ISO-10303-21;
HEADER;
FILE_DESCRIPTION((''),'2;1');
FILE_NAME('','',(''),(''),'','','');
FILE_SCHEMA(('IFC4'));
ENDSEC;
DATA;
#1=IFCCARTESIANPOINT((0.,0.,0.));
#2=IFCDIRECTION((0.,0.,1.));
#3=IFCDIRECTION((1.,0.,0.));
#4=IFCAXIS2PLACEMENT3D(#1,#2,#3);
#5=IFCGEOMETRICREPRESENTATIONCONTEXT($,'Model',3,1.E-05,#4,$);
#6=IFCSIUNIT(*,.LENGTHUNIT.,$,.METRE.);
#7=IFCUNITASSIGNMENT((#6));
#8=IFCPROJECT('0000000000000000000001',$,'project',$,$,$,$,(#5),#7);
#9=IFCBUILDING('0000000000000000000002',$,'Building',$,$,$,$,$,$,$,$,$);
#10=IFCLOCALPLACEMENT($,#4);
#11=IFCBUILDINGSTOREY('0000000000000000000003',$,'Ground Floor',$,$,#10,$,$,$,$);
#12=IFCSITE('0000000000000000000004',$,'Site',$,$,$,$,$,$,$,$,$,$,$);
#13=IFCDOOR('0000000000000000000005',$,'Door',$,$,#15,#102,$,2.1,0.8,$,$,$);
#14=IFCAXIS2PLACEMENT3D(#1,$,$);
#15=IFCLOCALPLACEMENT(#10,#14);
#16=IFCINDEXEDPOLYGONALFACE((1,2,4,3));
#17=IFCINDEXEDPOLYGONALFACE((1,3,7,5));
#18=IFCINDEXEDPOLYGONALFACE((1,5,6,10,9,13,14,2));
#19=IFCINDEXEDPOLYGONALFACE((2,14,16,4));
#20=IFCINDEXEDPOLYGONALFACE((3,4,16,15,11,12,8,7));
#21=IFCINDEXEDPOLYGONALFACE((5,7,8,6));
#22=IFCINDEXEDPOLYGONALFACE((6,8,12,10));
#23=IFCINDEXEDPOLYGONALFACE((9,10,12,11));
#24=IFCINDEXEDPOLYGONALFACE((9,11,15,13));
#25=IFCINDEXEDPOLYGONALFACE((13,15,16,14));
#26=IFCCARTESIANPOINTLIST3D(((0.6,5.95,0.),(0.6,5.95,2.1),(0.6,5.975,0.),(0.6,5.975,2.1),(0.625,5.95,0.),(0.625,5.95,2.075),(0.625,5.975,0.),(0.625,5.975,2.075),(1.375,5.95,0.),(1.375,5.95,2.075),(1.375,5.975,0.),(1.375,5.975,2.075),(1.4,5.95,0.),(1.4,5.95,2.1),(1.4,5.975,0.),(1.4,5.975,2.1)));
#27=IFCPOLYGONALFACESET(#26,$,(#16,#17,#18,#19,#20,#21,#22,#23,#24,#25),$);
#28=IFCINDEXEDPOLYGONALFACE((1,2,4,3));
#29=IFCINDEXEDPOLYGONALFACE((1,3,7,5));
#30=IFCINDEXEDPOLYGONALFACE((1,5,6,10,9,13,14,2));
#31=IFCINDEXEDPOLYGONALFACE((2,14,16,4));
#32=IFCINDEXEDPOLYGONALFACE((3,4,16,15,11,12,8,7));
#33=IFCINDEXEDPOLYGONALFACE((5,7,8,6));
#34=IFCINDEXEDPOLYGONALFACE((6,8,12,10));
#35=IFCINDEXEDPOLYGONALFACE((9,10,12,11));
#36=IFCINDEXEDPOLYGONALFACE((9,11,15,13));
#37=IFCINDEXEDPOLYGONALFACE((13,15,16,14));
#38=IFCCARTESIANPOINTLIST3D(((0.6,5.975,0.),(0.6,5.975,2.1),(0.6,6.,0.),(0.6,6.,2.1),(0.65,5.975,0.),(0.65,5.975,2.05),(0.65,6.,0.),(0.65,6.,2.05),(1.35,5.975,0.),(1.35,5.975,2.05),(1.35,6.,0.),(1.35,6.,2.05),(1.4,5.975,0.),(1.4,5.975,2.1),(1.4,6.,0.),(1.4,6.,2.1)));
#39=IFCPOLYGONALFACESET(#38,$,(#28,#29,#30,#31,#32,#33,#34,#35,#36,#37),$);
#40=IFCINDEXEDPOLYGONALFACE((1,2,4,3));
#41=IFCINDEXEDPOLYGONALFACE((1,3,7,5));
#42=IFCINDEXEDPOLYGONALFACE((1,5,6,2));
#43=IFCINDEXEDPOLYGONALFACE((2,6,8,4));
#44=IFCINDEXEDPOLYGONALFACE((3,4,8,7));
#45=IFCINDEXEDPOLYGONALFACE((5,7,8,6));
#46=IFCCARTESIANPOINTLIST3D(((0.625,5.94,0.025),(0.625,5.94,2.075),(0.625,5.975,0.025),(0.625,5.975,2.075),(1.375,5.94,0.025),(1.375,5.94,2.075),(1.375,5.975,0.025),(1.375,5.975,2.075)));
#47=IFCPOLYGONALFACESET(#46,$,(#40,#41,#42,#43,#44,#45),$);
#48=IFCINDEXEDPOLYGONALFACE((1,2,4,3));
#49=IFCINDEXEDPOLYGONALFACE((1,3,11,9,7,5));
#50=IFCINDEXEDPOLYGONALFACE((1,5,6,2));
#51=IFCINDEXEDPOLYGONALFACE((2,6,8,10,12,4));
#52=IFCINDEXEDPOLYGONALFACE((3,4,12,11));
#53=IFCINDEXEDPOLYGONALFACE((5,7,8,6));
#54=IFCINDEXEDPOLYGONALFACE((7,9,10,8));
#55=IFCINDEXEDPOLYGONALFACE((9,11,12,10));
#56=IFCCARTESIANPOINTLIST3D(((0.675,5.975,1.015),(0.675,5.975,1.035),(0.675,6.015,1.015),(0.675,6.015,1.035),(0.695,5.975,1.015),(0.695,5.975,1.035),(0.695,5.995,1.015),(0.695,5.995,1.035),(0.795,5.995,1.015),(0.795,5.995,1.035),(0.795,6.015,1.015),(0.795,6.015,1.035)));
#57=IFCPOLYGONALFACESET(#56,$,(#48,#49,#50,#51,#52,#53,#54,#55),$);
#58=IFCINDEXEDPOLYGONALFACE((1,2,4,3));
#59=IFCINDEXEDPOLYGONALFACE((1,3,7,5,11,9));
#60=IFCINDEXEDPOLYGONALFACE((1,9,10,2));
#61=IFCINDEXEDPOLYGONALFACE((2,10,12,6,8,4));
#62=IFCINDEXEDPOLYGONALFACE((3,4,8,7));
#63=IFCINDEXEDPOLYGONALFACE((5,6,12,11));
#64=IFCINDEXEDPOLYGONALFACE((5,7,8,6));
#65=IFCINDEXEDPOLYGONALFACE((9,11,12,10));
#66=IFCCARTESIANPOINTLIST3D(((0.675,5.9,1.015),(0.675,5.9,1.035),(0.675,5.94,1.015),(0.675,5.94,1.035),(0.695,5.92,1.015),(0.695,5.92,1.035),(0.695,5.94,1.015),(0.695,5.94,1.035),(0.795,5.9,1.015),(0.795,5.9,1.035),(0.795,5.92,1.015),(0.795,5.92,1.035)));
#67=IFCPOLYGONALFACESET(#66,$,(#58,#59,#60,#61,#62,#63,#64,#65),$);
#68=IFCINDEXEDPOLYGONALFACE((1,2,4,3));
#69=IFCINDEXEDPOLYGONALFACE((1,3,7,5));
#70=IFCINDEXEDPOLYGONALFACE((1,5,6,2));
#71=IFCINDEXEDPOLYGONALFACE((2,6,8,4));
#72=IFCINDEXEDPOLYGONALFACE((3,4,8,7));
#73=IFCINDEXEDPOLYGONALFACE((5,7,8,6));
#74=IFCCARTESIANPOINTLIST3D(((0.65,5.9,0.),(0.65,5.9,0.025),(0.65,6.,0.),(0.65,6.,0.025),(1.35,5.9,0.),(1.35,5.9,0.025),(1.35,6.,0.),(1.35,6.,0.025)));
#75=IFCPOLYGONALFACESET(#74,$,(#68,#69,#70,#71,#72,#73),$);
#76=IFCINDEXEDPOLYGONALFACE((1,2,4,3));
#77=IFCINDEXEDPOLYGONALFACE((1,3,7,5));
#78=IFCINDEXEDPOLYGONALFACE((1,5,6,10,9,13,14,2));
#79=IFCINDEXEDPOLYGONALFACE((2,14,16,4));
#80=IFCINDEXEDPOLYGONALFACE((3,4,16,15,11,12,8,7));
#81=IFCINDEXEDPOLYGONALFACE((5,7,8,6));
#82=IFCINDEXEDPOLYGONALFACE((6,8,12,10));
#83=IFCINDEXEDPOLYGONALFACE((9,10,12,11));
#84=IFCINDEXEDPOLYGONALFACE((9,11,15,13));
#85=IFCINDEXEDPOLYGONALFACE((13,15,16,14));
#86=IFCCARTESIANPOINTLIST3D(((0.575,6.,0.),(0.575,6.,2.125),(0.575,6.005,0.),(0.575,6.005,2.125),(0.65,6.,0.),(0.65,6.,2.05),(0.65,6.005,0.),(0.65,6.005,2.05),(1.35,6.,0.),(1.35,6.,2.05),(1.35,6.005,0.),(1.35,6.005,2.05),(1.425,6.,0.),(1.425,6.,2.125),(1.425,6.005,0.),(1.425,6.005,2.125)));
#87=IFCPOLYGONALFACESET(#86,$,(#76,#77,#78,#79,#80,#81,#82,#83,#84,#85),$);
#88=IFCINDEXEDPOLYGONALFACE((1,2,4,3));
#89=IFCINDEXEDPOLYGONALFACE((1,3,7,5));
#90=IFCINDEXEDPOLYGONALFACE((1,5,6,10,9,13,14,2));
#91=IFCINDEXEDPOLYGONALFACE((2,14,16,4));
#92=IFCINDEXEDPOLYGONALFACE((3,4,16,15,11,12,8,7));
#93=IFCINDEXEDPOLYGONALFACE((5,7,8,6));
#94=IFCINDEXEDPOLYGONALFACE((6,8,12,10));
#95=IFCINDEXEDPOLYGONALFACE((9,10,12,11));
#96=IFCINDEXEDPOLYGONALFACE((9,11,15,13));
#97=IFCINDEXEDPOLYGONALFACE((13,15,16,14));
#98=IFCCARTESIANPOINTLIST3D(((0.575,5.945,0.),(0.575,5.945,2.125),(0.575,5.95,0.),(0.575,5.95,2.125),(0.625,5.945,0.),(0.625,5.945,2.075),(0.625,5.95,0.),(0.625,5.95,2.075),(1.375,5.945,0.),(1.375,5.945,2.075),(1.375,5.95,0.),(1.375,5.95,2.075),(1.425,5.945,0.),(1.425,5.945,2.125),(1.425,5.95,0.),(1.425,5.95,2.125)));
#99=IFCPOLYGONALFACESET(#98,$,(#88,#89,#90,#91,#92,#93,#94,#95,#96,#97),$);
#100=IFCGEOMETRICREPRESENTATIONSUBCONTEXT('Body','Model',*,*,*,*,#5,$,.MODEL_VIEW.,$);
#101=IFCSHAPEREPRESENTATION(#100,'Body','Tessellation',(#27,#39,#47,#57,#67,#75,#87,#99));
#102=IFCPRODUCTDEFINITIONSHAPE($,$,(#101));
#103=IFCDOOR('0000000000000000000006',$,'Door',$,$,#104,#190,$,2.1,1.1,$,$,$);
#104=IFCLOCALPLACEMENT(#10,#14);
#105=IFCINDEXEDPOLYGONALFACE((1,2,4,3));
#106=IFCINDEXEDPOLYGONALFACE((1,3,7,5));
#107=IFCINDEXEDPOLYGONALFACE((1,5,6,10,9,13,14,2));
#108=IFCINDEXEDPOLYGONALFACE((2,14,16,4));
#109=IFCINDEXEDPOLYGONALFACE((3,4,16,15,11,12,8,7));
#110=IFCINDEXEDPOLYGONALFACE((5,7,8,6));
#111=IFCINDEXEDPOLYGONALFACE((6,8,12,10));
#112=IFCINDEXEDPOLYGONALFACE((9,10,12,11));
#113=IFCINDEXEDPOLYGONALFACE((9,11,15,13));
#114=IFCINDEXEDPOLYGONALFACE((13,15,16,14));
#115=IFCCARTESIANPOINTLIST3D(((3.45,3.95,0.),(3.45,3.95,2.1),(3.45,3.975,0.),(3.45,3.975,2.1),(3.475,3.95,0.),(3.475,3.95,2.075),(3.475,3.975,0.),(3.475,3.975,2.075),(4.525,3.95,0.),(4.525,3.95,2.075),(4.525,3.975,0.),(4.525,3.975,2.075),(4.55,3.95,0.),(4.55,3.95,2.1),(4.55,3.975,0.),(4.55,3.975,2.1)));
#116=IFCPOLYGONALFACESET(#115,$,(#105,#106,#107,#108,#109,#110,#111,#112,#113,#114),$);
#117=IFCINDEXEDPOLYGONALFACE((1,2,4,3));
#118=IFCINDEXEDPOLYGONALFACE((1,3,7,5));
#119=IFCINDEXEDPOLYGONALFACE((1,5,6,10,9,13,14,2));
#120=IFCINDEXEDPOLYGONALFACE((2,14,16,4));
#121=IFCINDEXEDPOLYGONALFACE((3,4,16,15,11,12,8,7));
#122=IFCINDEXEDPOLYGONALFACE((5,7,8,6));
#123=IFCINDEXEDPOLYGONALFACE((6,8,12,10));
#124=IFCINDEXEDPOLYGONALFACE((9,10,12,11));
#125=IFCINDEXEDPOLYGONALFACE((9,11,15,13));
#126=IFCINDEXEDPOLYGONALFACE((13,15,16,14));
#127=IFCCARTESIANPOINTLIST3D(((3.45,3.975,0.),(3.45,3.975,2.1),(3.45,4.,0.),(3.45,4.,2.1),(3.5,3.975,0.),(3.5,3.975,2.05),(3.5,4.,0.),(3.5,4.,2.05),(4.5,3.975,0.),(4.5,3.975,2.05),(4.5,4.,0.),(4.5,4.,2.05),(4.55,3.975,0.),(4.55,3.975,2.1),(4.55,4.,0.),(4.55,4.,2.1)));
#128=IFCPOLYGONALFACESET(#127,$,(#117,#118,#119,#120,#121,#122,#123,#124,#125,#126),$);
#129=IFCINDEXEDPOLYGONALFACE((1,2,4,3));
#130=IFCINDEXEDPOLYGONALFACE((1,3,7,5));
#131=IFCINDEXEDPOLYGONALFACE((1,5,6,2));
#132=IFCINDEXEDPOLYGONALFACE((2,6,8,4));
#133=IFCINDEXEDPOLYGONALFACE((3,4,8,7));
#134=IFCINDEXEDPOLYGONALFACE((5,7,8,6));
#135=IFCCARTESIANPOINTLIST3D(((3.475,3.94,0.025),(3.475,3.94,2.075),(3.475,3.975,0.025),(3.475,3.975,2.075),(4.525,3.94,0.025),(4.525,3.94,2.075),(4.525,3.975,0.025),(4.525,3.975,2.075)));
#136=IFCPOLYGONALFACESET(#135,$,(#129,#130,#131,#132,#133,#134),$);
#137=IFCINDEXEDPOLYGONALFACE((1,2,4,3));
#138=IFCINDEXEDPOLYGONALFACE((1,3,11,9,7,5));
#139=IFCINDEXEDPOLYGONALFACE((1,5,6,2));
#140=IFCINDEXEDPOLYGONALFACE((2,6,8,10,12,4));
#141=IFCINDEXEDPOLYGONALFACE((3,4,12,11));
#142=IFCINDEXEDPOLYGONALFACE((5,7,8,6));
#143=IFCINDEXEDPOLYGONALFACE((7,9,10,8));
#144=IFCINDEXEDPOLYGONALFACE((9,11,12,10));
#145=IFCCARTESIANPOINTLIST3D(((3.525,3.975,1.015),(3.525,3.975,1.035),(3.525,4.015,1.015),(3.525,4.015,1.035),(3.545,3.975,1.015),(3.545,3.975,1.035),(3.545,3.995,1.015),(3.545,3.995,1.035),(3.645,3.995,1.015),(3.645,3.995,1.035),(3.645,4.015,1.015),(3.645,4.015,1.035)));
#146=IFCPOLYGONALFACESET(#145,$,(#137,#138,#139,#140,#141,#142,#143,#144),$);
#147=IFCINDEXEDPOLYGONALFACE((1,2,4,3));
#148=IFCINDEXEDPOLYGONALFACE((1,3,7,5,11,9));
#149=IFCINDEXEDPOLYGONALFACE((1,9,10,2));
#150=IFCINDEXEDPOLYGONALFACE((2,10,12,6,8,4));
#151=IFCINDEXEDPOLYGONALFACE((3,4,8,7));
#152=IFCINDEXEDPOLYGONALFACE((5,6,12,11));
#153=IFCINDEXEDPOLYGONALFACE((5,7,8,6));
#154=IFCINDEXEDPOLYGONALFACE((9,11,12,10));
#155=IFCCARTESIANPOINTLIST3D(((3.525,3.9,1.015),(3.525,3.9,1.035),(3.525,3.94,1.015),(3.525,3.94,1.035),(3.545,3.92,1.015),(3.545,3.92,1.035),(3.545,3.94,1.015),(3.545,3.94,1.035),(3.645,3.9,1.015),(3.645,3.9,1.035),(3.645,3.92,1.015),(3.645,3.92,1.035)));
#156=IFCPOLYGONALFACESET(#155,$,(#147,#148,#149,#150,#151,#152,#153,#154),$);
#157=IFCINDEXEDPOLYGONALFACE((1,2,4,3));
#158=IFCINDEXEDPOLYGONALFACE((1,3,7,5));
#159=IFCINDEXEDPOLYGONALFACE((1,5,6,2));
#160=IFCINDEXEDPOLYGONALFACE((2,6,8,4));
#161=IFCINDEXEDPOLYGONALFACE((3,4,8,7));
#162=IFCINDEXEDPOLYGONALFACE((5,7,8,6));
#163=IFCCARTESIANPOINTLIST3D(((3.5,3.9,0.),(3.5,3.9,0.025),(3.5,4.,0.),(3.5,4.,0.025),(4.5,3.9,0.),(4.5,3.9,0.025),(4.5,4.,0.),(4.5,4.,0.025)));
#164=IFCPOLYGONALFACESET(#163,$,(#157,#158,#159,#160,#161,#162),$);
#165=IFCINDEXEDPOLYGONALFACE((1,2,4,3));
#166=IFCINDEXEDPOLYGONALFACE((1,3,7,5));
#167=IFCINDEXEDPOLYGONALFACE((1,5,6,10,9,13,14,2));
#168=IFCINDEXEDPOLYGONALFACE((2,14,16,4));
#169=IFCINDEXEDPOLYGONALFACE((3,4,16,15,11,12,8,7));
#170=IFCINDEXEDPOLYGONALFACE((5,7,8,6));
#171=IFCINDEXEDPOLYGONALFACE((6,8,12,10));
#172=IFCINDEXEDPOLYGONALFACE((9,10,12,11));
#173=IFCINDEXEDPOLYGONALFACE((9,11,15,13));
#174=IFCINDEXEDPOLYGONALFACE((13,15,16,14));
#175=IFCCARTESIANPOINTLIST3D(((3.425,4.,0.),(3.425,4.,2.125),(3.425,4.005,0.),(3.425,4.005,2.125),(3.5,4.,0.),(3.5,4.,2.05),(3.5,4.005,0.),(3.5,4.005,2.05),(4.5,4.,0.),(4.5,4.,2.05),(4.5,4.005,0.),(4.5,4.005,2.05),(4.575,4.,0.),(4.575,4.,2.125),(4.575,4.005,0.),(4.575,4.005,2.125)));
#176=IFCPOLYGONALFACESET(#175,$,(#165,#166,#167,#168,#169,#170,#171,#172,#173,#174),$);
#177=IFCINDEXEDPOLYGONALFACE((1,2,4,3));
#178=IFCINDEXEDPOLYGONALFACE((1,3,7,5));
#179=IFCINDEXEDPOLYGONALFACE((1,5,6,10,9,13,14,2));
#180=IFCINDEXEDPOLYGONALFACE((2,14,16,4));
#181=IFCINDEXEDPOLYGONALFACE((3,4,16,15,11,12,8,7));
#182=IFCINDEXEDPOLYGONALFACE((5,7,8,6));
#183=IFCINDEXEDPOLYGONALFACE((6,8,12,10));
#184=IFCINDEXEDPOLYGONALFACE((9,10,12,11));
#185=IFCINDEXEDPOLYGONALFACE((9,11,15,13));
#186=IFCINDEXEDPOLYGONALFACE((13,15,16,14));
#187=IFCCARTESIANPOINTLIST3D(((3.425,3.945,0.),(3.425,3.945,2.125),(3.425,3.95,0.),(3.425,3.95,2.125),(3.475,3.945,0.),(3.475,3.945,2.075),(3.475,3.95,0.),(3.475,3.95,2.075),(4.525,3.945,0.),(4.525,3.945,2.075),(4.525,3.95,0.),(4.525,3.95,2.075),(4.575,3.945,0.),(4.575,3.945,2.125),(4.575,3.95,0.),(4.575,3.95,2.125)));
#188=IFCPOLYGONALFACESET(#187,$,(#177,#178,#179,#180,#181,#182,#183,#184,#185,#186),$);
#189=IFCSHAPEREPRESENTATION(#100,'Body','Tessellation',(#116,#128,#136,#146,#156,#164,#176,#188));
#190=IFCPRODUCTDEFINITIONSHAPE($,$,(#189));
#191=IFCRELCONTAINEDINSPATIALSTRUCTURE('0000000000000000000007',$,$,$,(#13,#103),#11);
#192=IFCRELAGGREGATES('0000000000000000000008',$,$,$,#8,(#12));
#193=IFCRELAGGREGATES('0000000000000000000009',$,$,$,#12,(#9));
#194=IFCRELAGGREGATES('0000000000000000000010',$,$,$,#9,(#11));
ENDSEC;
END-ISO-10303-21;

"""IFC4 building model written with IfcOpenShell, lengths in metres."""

from ifc_helpers import new_model, si_unit, frame, origin_with_axes, place, context, subcontext, project, spatial, line, indexed_curve, outline, extrude, element, save


model = new_model("IFC4")

# Units and contexts
model_context = context("Model", 3, precision=1e-05, world=origin_with_axes())
body_context = subcontext(model_context, "Body", "Model", "MODEL_VIEW")
ifc_project = project(units=[si_unit("LENGTHUNIT", "METRE")], contexts=[model_context])

# Site, building, storey
site = spatial("IfcSite", under=ifc_project, Name="Site")
building = spatial("IfcBuilding", under=site, Name="Building")
storey_placement = place(None, origin_with_axes())
storey = spatial("IfcBuildingStorey", under=building, at=storey_placement, Name="Ground Floor")

# Doors
door_1_placement = place(storey_placement, frame((1.4, 6.0, 0.0), z_axis=(0.0, 0.0, 1.0), x_axis=(-1.0, 0.0, 0.0)))
element("IfcDoor", 1, at=door_1_placement, inside=storey, Name="Door", OverallHeight=2.1, OverallWidth=0.8, context=body_context, shape_type="SweptSolid", body=[
    extrude(outline(indexed_curve([(0.0, 0.0), (0.0, 2.1), (0.8, 2.1), (0.8, 0.0), (0.775, 0.0), (0.775, 2.075), (0.025, 2.075), (0.025, 0.0)], segments=[line(1, 2, 3, 4, 5, 6, 7, 8, 1)])), frame((0.0, 0.025, 0.0), z_axis=(0.0, -1.0, 0.0), x_axis=(1.0, 0.0, 0.0)), (0.0, 0.0, -1.0), 0.025),
    extrude(outline(indexed_curve([(0.0, 0.0), (0.0, 2.1), (0.8, 2.1), (0.8, 0.0), (0.75, 0.0), (0.75, 2.05), (0.05, 2.05), (0.05, 0.0)], segments=[line(1, 2, 3, 4, 5, 6, 7, 8, 1)])), frame((0.0, 0.0, 0.0), z_axis=(0.0, -1.0, 0.0), x_axis=(1.0, 0.0, 0.0)), (0.0, 0.0, -1.0), 0.025),
    extrude(outline(indexed_curve([(0.0, 0.0), (0.75, 0.0), (0.75, 0.035), (0.0, 0.035)], segments=[line(1, 2, 3, 4, 1)])), frame((0.025, 0.025, 0.025), z_axis=(0.0, 0.0, 1.0), x_axis=(1.0, 0.0, 0.0)), (0.0, 0.0, 1.0), 2.05),
    extrude(outline(indexed_curve([(0.0, 0.0), (0.0, -0.04), (-0.12, -0.04), (-0.12, -0.02), (-0.02, -0.02), (-0.02, 0.0)], segments=[line(1, 2, 3, 4, 5, 6, 1)])), frame((0.725, 0.025, 1.015), z_axis=(0.0, 0.0, 1.0), x_axis=(1.0, 0.0, 0.0)), (0.0, 0.0, 1.0), 0.02),
    extrude(outline(indexed_curve([(0.0, 0.0), (0.0, 0.04), (-0.12, 0.04), (-0.12, 0.02), (-0.02, 0.02), (-0.02, 0.0)], segments=[line(1, 2, 3, 4, 5, 6, 1)])), frame((0.725, 0.06, 1.015), z_axis=(0.0, 0.0, 1.0), x_axis=(1.0, 0.0, 0.0)), (0.0, 0.0, 1.0), 0.02),
    extrude(outline(indexed_curve([(0.0, 0.0), (0.7, 0.0), (0.7, 0.1), (0.0, 0.1)], segments=[line(1, 2, 3, 4, 1)])), frame((0.05, 0.0, 0.0), z_axis=(0.0, 0.0, 1.0), x_axis=(1.0, 0.0, 0.0)), (0.0, 0.0, 1.0), 0.025),
    extrude(outline(indexed_curve([(0.0, 0.0), (0.0, 2.125), (0.85, 2.125), (0.85, 0.0), (0.775, 0.0), (0.775, 2.05), (0.075, 2.05), (0.075, 0.0)], segments=[line(1, 2, 3, 4, 5, 6, 7, 8, 1)])), frame((-0.025, -0.005, 0.0), z_axis=(0.0, -1.0, 0.0), x_axis=(1.0, 0.0, 0.0)), (0.0, 0.0, -1.0), 0.005),
    extrude(outline(indexed_curve([(0.0, 0.0), (0.0, 2.125), (0.85, 2.125), (0.85, 0.0), (0.8, 0.0), (0.8, 2.075), (0.05, 2.075), (0.05, 0.0)], segments=[line(1, 2, 3, 4, 5, 6, 7, 8, 1)])), frame((-0.025, 0.05, 0.0), z_axis=(0.0, -1.0, 0.0), x_axis=(1.0, 0.0, 0.0)), (0.0, 0.0, -1.0), 0.005),
])
door_2_placement = place(storey_placement, frame((4.55, 4.0, 0.0), z_axis=(0.0, 0.0, 1.0), x_axis=(-1.0, 0.0, 0.0)))
element("IfcDoor", 2, at=door_2_placement, inside=storey, Name="Door", OverallHeight=2.1, OverallWidth=1.1, context=body_context, shape_type="SweptSolid", body=[
    extrude(outline(indexed_curve([(0.0, 0.0), (0.0, 2.1), (1.1, 2.1), (1.1, 0.0), (1.075, 0.0), (1.075, 2.075), (0.025, 2.075), (0.025, 0.0)], segments=[line(1, 2, 3, 4, 5, 6, 7, 8, 1)])), frame((0.0, 0.025, 0.0), z_axis=(0.0, -1.0, 0.0), x_axis=(1.0, 0.0, 0.0)), (0.0, 0.0, -1.0), 0.025),
    extrude(outline(indexed_curve([(0.0, 0.0), (0.0, 2.1), (1.1, 2.1), (1.1, 0.0), (1.05, 0.0), (1.05, 2.05), (0.05, 2.05), (0.05, 0.0)], segments=[line(1, 2, 3, 4, 5, 6, 7, 8, 1)])), frame((0.0, 0.0, 0.0), z_axis=(0.0, -1.0, 0.0), x_axis=(1.0, 0.0, 0.0)), (0.0, 0.0, -1.0), 0.025),
    extrude(outline(indexed_curve([(0.0, 0.0), (1.05, 0.0), (1.05, 0.035), (0.0, 0.035)], segments=[line(1, 2, 3, 4, 1)])), frame((0.025, 0.025, 0.025), z_axis=(0.0, 0.0, 1.0), x_axis=(1.0, 0.0, 0.0)), (0.0, 0.0, 1.0), 2.05),
    extrude(outline(indexed_curve([(0.0, 0.0), (0.0, -0.04), (-0.12, -0.04), (-0.12, -0.02), (-0.02, -0.02), (-0.02, 0.0)], segments=[line(1, 2, 3, 4, 5, 6, 1)])), frame((1.025, 0.025, 1.015), z_axis=(0.0, 0.0, 1.0), x_axis=(1.0, 0.0, 0.0)), (0.0, 0.0, 1.0), 0.02),
    extrude(outline(indexed_curve([(0.0, 0.0), (0.0, 0.04), (-0.12, 0.04), (-0.12, 0.02), (-0.02, 0.02), (-0.02, 0.0)], segments=[line(1, 2, 3, 4, 5, 6, 1)])), frame((1.025, 0.06, 1.015), z_axis=(0.0, 0.0, 1.0), x_axis=(1.0, 0.0, 0.0)), (0.0, 0.0, 1.0), 0.02),
    extrude(outline(indexed_curve([(0.0, 0.0), (1.0, 0.0), (1.0, 0.1), (0.0, 0.1)], segments=[line(1, 2, 3, 4, 1)])), frame((0.05, 0.0, 0.0), z_axis=(0.0, 0.0, 1.0), x_axis=(1.0, 0.0, 0.0)), (0.0, 0.0, 1.0), 0.025),
    extrude(outline(indexed_curve([(0.0, 0.0), (0.0, 2.125), (1.15, 2.125), (1.15, 0.0), (1.075, 0.0), (1.075, 2.05), (0.075, 2.05), (0.075, 0.0)], segments=[line(1, 2, 3, 4, 5, 6, 7, 8, 1)])), frame((-0.025, -0.005, 0.0), z_axis=(0.0, -1.0, 0.0), x_axis=(1.0, 0.0, 0.0)), (0.0, 0.0, -1.0), 0.005),
    extrude(outline(indexed_curve([(0.0, 0.0), (0.0, 2.125), (1.15, 2.125), (1.15, 0.0), (1.1, 0.0), (1.1, 2.075), (0.05, 2.075), (0.05, 0.0)], segments=[line(1, 2, 3, 4, 5, 6, 7, 8, 1)])), frame((-0.025, 0.05, 0.0), z_axis=(0.0, -1.0, 0.0), x_axis=(1.0, 0.0, 0.0)), (0.0, 0.0, -1.0), 0.005),
])

save(model, "model.ifc")
